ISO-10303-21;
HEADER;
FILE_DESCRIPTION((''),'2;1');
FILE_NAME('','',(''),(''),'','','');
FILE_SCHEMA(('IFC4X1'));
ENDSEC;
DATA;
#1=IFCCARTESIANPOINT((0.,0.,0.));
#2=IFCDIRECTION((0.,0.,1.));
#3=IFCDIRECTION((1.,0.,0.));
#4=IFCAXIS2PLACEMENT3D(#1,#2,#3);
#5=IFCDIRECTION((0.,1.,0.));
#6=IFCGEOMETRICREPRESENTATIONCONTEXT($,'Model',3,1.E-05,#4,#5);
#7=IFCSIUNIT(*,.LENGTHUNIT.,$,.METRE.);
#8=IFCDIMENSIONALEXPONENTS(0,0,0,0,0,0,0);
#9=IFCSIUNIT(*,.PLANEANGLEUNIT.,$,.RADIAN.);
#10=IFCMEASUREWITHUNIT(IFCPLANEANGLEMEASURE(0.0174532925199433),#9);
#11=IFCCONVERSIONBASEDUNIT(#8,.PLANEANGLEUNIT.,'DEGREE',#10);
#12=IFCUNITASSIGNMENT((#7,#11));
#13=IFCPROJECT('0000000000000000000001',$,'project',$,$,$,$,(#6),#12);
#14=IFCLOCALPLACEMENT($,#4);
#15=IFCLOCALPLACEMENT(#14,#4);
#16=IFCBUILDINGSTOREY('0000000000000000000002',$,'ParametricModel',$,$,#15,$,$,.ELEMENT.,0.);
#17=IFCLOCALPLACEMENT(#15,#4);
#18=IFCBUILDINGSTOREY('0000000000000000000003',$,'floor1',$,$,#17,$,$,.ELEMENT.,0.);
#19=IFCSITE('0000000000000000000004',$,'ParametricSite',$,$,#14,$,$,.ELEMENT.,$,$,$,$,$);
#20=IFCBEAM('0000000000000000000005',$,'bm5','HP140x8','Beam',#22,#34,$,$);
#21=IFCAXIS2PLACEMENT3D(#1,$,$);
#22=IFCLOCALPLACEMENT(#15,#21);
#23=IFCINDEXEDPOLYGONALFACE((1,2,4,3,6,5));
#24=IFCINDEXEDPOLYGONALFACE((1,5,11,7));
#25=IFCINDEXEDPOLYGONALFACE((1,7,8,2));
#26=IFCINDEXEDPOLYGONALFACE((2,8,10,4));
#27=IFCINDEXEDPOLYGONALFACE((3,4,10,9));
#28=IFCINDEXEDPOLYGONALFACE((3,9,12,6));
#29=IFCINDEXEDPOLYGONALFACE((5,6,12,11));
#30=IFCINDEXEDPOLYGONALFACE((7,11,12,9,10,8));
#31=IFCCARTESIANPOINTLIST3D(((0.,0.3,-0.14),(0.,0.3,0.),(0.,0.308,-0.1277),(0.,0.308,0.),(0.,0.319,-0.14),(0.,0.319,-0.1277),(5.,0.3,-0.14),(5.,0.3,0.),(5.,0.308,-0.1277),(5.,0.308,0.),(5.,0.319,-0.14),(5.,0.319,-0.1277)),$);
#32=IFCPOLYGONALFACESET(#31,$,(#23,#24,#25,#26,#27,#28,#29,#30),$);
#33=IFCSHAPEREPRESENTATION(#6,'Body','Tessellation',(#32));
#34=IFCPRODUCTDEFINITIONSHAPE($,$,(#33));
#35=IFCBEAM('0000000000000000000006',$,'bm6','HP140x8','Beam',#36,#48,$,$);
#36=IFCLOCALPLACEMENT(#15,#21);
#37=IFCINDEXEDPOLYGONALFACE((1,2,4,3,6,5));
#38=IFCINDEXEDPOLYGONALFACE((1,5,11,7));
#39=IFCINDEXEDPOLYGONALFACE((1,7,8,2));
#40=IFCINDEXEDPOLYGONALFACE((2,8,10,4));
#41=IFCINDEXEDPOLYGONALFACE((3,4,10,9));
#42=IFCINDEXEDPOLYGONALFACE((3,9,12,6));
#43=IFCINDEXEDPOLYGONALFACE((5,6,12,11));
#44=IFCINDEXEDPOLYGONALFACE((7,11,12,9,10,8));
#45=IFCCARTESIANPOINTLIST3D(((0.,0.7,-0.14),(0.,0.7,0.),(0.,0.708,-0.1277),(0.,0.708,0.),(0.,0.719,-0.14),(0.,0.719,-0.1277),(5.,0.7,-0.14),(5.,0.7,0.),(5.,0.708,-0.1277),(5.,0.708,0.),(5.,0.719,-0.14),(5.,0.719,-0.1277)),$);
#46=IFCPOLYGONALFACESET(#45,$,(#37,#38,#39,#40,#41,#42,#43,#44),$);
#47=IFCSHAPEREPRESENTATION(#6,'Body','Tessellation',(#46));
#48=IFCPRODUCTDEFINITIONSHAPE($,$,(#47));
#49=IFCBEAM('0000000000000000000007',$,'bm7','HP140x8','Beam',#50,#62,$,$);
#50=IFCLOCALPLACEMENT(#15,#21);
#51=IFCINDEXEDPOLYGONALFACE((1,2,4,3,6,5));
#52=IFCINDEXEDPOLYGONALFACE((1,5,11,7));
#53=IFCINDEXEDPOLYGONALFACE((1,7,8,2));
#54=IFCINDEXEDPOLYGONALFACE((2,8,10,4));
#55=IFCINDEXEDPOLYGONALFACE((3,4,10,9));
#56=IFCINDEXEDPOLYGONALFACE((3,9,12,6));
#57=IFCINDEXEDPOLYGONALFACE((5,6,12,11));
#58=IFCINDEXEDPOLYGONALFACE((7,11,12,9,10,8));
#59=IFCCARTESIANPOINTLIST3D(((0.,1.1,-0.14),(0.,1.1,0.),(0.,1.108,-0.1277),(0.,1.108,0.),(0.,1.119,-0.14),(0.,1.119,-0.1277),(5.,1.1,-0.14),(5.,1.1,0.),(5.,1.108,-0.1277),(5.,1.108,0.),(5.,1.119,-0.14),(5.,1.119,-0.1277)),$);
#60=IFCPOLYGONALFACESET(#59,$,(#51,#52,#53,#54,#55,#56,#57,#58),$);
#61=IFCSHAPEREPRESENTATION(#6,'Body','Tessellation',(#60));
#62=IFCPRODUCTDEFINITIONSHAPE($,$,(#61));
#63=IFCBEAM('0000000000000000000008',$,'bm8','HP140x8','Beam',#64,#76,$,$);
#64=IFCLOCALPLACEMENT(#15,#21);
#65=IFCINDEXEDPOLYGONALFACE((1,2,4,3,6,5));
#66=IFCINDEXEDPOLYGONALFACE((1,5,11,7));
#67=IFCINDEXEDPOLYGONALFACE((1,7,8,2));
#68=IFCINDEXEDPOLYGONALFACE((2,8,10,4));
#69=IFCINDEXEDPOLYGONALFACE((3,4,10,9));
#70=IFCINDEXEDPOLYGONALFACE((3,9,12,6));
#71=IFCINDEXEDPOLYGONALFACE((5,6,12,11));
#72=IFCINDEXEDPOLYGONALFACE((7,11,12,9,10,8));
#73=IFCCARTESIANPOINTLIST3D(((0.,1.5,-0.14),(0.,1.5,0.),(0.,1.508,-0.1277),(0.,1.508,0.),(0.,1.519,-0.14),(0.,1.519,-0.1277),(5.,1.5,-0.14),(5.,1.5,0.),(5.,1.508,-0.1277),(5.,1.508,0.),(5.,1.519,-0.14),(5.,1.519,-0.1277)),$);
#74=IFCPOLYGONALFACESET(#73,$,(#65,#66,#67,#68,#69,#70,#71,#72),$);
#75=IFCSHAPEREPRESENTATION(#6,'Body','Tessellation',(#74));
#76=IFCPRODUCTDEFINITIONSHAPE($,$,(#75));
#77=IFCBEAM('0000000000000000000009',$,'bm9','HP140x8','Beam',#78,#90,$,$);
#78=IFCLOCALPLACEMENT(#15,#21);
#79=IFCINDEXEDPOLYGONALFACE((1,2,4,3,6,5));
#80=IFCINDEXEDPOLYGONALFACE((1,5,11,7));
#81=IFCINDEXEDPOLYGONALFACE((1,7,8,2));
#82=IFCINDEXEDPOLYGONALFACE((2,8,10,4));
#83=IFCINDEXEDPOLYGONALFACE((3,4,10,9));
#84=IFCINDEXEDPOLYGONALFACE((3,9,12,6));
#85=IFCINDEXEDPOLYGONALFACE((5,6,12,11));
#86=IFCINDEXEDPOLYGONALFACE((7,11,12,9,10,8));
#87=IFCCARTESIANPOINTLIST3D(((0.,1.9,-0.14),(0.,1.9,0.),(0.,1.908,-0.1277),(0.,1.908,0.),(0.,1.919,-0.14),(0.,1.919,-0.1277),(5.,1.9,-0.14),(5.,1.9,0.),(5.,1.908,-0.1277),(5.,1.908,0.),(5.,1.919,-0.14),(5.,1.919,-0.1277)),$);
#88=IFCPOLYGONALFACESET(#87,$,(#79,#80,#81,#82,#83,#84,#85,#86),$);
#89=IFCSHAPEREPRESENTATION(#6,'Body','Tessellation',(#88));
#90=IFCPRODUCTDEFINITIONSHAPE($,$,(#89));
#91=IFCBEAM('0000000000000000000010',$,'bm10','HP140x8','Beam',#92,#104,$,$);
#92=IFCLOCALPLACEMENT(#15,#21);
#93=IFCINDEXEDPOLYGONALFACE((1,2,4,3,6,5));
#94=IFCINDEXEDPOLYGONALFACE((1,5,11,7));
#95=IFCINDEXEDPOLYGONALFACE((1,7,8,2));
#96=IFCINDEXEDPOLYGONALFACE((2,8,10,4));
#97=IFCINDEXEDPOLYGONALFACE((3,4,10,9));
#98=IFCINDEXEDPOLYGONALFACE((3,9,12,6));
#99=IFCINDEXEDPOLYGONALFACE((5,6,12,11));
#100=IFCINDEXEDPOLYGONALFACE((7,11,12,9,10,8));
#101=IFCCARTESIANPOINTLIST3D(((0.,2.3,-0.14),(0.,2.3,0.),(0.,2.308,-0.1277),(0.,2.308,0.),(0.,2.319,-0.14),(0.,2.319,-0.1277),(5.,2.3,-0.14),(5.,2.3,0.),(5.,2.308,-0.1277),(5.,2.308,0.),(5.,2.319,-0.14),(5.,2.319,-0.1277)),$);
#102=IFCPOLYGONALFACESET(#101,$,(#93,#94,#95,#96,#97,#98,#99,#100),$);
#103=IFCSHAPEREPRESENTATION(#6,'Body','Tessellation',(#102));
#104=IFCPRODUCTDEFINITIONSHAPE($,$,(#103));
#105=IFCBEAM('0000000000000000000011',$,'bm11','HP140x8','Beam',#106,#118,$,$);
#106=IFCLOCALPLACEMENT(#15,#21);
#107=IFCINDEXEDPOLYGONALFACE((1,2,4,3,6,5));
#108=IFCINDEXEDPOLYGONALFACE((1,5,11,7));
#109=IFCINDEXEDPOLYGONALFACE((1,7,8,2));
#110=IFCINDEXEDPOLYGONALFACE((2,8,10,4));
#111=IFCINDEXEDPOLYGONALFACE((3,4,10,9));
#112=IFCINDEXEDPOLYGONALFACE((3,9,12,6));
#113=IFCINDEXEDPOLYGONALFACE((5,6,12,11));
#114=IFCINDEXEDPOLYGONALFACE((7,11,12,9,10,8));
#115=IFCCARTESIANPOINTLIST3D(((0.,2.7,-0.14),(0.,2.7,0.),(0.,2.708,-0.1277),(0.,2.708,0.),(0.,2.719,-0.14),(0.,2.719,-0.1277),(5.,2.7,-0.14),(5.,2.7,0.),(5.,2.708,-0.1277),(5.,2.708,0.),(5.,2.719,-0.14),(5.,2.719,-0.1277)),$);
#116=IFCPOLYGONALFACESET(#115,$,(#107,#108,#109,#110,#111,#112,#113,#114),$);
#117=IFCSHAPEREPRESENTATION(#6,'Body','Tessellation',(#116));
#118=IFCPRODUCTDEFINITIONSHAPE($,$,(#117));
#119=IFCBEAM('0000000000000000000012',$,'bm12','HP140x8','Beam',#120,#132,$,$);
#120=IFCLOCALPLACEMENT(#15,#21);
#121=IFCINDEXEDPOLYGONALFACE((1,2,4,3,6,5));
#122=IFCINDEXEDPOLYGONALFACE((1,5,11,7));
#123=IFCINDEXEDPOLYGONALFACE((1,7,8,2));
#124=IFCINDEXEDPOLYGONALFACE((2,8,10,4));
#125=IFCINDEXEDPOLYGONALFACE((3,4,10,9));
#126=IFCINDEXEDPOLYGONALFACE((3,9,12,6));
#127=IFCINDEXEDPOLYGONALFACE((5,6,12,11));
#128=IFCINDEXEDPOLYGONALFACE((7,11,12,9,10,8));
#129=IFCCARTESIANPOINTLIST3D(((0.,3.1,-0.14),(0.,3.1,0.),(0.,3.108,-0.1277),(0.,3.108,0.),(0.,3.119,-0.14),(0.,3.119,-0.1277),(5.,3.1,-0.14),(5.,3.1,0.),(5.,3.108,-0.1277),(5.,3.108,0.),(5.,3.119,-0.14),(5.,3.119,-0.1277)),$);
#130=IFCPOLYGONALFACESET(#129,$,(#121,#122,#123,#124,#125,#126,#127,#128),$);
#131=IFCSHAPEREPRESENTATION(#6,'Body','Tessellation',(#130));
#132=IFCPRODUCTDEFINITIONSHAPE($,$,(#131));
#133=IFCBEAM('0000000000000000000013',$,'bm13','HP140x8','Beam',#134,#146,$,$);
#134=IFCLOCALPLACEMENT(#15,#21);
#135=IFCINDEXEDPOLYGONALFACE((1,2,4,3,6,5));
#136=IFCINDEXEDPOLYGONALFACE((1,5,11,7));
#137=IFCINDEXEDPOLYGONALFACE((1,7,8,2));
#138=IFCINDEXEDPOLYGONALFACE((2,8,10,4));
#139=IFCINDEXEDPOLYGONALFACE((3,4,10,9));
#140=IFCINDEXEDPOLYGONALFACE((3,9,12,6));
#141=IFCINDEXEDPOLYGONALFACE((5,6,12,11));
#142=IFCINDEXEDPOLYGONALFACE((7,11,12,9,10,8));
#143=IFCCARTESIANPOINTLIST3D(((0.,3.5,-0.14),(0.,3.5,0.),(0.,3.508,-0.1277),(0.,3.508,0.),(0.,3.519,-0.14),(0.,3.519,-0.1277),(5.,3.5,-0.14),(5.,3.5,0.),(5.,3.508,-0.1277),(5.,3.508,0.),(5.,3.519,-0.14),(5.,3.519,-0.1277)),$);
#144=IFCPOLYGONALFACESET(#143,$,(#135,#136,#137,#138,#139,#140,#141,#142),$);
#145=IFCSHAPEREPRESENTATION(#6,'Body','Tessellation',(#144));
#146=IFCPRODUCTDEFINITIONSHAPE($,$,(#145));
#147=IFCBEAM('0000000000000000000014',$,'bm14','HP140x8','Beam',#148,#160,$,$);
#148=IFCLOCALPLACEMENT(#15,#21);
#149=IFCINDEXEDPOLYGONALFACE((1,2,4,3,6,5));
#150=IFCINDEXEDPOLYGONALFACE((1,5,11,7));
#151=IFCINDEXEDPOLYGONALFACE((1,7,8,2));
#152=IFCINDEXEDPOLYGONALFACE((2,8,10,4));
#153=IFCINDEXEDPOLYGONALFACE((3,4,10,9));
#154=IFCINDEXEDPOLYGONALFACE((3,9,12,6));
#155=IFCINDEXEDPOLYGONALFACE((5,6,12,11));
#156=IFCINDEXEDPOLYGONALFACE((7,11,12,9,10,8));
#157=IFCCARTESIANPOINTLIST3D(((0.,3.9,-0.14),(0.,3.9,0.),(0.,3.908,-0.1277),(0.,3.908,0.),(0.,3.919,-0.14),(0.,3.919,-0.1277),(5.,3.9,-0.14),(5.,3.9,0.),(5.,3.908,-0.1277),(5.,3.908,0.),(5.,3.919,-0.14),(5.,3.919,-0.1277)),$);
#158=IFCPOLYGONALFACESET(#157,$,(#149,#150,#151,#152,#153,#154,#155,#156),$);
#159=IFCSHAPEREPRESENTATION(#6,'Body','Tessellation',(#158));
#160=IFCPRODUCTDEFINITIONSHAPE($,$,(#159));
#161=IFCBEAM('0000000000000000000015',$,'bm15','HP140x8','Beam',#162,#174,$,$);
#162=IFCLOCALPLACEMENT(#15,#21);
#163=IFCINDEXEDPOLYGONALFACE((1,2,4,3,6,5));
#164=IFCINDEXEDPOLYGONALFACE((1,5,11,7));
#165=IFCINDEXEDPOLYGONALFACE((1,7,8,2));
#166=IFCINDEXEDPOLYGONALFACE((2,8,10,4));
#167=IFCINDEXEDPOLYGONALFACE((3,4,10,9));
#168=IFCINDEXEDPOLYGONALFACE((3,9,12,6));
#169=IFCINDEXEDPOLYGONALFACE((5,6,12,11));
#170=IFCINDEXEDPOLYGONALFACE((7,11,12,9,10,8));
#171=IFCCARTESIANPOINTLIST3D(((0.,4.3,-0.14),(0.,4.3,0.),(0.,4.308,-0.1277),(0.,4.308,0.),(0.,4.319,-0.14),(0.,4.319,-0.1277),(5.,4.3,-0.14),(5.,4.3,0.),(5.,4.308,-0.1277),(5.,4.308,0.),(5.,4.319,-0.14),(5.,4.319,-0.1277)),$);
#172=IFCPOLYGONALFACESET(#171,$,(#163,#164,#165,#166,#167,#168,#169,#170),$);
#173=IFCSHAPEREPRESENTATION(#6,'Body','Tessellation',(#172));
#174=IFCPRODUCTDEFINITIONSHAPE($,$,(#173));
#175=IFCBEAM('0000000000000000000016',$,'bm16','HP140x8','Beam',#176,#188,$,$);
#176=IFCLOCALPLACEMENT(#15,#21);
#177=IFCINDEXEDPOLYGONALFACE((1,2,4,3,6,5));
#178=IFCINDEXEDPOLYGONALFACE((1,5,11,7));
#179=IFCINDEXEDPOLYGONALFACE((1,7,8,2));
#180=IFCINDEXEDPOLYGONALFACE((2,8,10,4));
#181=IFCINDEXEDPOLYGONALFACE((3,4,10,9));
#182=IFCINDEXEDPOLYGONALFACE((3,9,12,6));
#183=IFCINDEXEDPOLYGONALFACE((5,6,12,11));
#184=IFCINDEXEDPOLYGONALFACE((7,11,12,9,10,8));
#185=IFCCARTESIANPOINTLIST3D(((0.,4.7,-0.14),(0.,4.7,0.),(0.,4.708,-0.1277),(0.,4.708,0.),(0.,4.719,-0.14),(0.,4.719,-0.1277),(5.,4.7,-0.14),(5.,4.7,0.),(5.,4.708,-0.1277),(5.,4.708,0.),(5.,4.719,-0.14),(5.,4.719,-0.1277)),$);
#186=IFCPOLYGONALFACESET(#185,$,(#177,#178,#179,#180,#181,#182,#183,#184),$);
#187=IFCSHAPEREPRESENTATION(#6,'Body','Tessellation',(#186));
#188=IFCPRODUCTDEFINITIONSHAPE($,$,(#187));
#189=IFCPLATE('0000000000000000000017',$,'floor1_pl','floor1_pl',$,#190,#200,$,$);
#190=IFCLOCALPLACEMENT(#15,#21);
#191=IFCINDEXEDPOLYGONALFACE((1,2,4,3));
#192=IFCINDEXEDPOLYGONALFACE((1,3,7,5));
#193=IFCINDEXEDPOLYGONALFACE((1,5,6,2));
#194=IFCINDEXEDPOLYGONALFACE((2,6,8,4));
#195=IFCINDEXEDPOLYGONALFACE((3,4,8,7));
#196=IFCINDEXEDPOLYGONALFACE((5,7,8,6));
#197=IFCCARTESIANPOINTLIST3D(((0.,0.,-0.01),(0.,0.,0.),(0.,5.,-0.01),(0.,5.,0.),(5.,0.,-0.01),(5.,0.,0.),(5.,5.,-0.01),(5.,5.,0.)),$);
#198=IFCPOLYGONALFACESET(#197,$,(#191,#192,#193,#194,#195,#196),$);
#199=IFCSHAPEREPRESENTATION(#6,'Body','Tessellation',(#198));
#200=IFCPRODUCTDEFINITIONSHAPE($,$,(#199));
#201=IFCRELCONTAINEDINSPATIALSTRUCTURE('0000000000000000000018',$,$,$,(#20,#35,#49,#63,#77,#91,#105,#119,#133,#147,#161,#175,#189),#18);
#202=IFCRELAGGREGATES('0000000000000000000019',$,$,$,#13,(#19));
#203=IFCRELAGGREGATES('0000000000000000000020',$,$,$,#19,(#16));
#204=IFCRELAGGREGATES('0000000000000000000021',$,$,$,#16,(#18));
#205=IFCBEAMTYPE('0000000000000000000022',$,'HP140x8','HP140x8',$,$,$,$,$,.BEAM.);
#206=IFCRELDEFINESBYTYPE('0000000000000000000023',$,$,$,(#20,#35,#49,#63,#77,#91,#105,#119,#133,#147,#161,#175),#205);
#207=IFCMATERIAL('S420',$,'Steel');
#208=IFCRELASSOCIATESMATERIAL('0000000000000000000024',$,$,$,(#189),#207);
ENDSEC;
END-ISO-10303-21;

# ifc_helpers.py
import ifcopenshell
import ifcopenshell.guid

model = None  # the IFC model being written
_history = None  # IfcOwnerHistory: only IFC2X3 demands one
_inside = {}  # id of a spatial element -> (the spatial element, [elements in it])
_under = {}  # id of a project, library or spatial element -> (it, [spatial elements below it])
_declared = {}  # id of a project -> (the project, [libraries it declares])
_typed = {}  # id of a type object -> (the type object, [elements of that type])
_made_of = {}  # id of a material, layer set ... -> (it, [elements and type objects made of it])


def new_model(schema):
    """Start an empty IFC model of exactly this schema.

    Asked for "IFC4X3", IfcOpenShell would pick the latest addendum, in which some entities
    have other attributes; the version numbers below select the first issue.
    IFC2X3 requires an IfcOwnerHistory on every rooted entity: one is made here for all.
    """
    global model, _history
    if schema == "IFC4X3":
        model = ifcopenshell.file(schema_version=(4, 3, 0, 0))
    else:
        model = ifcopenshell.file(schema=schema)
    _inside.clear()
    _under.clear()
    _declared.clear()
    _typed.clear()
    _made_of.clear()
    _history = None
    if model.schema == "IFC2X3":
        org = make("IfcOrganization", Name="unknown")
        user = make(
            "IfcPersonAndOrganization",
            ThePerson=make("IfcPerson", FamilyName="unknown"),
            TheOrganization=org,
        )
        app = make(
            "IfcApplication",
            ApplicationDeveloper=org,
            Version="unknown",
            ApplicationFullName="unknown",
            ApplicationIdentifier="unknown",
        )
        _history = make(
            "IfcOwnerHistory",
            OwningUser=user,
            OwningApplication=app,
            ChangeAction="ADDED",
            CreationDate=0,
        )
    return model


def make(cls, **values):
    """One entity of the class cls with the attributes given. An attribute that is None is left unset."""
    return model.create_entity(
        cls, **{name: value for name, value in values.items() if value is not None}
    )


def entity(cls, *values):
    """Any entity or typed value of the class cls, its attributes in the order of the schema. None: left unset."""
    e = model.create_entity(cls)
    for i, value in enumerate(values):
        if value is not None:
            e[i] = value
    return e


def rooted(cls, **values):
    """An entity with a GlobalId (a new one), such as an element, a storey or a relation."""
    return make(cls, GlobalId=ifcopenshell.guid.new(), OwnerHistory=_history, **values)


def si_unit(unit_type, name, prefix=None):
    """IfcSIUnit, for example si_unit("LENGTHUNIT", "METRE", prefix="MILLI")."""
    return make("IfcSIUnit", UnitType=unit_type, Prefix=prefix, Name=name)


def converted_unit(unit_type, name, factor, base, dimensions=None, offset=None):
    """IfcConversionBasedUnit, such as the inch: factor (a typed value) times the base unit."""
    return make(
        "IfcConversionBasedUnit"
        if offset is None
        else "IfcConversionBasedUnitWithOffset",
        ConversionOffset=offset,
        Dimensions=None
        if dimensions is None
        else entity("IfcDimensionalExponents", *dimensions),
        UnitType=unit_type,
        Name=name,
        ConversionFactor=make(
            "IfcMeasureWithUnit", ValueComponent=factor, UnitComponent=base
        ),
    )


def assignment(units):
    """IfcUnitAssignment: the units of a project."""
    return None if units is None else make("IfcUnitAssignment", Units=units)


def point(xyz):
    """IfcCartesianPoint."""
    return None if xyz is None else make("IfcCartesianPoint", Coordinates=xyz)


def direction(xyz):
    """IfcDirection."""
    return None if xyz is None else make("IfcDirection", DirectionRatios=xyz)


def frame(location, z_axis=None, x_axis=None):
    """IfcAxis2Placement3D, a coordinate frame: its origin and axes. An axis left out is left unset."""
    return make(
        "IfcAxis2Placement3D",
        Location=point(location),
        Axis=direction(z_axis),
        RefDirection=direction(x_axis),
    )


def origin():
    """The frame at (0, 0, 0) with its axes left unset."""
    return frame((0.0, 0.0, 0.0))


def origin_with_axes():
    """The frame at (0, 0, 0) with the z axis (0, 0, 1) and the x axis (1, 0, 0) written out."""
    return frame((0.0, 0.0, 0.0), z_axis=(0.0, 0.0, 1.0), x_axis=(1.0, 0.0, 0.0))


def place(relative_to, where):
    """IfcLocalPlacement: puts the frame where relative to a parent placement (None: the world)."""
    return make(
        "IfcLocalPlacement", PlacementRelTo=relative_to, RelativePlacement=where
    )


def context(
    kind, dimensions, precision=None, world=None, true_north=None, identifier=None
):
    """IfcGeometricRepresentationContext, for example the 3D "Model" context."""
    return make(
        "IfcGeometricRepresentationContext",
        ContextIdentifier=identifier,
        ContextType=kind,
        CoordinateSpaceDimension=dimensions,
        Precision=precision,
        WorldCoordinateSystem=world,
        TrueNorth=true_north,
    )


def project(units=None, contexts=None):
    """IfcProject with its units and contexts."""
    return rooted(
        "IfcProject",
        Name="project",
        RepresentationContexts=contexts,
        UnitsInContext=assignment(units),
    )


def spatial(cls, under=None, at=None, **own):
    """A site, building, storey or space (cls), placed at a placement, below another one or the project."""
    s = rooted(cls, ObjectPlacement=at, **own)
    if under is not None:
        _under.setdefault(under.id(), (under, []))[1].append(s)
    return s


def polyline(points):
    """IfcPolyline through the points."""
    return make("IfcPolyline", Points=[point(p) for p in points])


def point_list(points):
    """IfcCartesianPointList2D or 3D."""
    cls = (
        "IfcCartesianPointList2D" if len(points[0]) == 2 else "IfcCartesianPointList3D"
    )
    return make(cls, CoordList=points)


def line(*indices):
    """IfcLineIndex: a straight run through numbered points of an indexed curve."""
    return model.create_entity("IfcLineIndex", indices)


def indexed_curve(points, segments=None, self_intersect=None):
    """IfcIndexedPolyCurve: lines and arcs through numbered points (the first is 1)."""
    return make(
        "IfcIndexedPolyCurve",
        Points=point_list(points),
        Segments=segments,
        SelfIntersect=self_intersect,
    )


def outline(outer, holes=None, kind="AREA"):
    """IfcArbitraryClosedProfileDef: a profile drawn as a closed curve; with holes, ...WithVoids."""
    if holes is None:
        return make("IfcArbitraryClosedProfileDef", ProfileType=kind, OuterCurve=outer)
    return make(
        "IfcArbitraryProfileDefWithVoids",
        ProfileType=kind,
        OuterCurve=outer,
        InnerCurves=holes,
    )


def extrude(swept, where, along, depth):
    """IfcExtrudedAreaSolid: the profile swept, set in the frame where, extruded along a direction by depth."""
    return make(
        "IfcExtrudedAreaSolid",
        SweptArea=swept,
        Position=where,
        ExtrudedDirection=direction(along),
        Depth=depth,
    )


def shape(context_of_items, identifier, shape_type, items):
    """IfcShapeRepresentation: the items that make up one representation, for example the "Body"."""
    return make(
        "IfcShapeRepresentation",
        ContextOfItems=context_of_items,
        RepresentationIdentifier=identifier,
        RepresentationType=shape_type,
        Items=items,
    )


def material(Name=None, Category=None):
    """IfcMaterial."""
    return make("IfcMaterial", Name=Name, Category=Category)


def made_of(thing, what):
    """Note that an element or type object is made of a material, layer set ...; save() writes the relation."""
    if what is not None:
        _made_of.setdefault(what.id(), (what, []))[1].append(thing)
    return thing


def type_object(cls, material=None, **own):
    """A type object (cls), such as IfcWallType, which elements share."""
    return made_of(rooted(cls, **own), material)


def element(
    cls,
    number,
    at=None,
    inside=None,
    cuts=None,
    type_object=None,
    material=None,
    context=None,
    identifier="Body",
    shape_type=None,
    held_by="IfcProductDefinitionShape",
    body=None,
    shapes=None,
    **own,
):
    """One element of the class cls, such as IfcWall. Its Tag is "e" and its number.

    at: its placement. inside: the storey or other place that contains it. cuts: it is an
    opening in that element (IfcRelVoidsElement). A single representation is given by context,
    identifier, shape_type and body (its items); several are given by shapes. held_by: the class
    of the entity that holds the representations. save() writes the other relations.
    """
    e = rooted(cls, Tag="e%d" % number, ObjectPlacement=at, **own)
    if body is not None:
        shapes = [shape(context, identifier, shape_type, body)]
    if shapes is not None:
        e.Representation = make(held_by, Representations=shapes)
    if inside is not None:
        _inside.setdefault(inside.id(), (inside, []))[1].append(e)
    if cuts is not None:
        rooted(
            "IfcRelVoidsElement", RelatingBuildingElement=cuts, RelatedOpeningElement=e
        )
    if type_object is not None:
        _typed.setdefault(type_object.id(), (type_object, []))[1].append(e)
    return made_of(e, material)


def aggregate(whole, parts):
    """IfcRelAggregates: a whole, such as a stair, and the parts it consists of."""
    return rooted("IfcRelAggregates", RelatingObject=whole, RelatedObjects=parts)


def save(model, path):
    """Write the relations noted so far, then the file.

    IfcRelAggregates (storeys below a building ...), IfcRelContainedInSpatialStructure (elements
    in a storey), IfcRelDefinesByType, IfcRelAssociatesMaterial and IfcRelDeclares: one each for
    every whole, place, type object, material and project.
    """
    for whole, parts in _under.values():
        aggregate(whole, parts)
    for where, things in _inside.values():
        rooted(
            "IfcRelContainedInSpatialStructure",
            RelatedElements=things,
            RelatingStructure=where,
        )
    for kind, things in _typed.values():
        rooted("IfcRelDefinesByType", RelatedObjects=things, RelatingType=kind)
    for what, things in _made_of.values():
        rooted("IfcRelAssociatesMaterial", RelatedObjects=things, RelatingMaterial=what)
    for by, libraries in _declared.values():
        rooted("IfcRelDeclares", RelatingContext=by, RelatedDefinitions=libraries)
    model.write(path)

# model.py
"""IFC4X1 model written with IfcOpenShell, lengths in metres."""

from ifc_helpers import new_model, entity, si_unit, converted_unit, direction, frame, origin, origin_with_axes, place, context, project, spatial, polyline, line, indexed_curve, outline, extrude, material, type_object, element, save


model = new_model("IFC4X1")

# Units and contexts
model_context = context("Model", 3, precision=1e-05, world=origin_with_axes(), true_north=direction((0.0, 1.0, 0.0)))
ifc_project = project(units=[si_unit("LENGTHUNIT", "METRE"), converted_unit("PLANEANGLEUNIT", "DEGREE", entity("IfcPlaneAngleMeasure", 0.0174532925199433), si_unit("PLANEANGLEUNIT", "RADIAN"), dimensions=[0, 0, 0, 0, 0, 0, 0])], contexts=[model_context])

# Site, storeys
site_placement = place(None, origin_with_axes())
site = spatial("IfcSite", under=ifc_project, at=site_placement, Name="ParametricSite", CompositionType="ELEMENT")
storey_1_placement = place(site_placement, origin_with_axes())
storey_1 = spatial("IfcBuildingStorey", under=site, at=storey_1_placement, Name="ParametricModel", CompositionType="ELEMENT", Elevation=0.0)
storey_2_placement = place(storey_1_placement, origin_with_axes())
storey_2 = spatial("IfcBuildingStorey", under=storey_1, at=storey_2_placement, Name="floor1", CompositionType="ELEMENT", Elevation=0.0)

# Beams
beam_type = type_object("IfcBeamType", Name="HP140x8", Description="HP140x8", PredefinedType="BEAM")
plate_placement = place(storey_2_placement, origin_with_axes())
for number, where, z_axis, x_axis, name in (
    (1, (0.0, 0.3, 0.0), (1.0, 0.0, 0.0), (0.0, 1.0, 0.0), "bm5"),
    (2, (0.0, 0.7, 0.0), (1.0, 0.0, 0.0), (0.0, 1.0, 0.0), "bm6"),
    (3, (0.0, 1.1, 0.0), (1.0, 0.0, 0.0), (0.0, 1.0, 0.0), "bm7"),
    (4, (0.0, 1.5, 0.0), (1.0, 0.0, 0.0), (0.0, 1.0, 0.0), "bm8"),
    (5, (0.0, 1.9, 0.0), (1.0, 0.0, 0.0), (0.0, 1.0, 0.0), "bm9"),
    (6, (0.0, 2.3, 0.0), (1.0, 0.0, 0.0), (0.0, 1.0, 0.0), "bm10"),
    (7, (0.0, 2.7, 0.0), (1.0, 0.0, 0.0), (0.0, 1.0, 0.0), "bm11"),
    (8, (0.0, 3.1, 0.0), (1.0, 0.0, 0.0), (0.0, 1.0, 0.0), "bm12"),
    (9, (0.0, 3.5, 0.0), (1.0, 0.0, 0.0), (0.0, 1.0, 0.0), "bm13"),
    (10, (0.0, 3.9, 0.0), (1.0, 0.0, 0.0), (0.0, 1.0, 0.0), "bm14"),
    (11, (0.0, 4.3, 0.0), (1.0, 0.0, 0.0), (0.0, 1.0, 0.0), "bm15"),
    (12, (0.0, 4.7, 0.0), (1.0, 0.0, 0.0), (0.0, 1.0, 0.0), "bm16"),
):
    element("IfcBeam", number, at=place(plate_placement, frame(where, z_axis=z_axis, x_axis=x_axis)), inside=storey_2, type_object=beam_type, Name=name, Description="HP140x8", ObjectType="Beam", context=model_context, shape_type="SweptSolid", body=[
        extrude(outline(polyline([(0.0, 0.0), (0.008, 0.0), (0.008, -0.1277), (0.019, -0.1277), (0.019, -0.14), (0.0, -0.14)])), origin(), (0.0, 0.0, 1.0), 5.0),
    ])

# Plate
ifc_material = material(Name="S420", Category="Steel")
element("IfcPlate", 13, at=plate_placement, inside=storey_2, material=ifc_material, Name="floor1_pl", Description="floor1_pl", context=model_context, shape_type="SolidModel", body=[
    extrude(outline(indexed_curve([(0.0, 5.0, 0.0), (0.0, 0.0, 0.0), (5.0, 0.0, 0.0), (5.0, 5.0, 0.0)], segments=[line(1, 2), line(2, 3), line(3, 4), line(4, 1)])), origin_with_axes(), (0.0, 0.0, -1.0), 0.01),
])

save(model, "model.ifc")
